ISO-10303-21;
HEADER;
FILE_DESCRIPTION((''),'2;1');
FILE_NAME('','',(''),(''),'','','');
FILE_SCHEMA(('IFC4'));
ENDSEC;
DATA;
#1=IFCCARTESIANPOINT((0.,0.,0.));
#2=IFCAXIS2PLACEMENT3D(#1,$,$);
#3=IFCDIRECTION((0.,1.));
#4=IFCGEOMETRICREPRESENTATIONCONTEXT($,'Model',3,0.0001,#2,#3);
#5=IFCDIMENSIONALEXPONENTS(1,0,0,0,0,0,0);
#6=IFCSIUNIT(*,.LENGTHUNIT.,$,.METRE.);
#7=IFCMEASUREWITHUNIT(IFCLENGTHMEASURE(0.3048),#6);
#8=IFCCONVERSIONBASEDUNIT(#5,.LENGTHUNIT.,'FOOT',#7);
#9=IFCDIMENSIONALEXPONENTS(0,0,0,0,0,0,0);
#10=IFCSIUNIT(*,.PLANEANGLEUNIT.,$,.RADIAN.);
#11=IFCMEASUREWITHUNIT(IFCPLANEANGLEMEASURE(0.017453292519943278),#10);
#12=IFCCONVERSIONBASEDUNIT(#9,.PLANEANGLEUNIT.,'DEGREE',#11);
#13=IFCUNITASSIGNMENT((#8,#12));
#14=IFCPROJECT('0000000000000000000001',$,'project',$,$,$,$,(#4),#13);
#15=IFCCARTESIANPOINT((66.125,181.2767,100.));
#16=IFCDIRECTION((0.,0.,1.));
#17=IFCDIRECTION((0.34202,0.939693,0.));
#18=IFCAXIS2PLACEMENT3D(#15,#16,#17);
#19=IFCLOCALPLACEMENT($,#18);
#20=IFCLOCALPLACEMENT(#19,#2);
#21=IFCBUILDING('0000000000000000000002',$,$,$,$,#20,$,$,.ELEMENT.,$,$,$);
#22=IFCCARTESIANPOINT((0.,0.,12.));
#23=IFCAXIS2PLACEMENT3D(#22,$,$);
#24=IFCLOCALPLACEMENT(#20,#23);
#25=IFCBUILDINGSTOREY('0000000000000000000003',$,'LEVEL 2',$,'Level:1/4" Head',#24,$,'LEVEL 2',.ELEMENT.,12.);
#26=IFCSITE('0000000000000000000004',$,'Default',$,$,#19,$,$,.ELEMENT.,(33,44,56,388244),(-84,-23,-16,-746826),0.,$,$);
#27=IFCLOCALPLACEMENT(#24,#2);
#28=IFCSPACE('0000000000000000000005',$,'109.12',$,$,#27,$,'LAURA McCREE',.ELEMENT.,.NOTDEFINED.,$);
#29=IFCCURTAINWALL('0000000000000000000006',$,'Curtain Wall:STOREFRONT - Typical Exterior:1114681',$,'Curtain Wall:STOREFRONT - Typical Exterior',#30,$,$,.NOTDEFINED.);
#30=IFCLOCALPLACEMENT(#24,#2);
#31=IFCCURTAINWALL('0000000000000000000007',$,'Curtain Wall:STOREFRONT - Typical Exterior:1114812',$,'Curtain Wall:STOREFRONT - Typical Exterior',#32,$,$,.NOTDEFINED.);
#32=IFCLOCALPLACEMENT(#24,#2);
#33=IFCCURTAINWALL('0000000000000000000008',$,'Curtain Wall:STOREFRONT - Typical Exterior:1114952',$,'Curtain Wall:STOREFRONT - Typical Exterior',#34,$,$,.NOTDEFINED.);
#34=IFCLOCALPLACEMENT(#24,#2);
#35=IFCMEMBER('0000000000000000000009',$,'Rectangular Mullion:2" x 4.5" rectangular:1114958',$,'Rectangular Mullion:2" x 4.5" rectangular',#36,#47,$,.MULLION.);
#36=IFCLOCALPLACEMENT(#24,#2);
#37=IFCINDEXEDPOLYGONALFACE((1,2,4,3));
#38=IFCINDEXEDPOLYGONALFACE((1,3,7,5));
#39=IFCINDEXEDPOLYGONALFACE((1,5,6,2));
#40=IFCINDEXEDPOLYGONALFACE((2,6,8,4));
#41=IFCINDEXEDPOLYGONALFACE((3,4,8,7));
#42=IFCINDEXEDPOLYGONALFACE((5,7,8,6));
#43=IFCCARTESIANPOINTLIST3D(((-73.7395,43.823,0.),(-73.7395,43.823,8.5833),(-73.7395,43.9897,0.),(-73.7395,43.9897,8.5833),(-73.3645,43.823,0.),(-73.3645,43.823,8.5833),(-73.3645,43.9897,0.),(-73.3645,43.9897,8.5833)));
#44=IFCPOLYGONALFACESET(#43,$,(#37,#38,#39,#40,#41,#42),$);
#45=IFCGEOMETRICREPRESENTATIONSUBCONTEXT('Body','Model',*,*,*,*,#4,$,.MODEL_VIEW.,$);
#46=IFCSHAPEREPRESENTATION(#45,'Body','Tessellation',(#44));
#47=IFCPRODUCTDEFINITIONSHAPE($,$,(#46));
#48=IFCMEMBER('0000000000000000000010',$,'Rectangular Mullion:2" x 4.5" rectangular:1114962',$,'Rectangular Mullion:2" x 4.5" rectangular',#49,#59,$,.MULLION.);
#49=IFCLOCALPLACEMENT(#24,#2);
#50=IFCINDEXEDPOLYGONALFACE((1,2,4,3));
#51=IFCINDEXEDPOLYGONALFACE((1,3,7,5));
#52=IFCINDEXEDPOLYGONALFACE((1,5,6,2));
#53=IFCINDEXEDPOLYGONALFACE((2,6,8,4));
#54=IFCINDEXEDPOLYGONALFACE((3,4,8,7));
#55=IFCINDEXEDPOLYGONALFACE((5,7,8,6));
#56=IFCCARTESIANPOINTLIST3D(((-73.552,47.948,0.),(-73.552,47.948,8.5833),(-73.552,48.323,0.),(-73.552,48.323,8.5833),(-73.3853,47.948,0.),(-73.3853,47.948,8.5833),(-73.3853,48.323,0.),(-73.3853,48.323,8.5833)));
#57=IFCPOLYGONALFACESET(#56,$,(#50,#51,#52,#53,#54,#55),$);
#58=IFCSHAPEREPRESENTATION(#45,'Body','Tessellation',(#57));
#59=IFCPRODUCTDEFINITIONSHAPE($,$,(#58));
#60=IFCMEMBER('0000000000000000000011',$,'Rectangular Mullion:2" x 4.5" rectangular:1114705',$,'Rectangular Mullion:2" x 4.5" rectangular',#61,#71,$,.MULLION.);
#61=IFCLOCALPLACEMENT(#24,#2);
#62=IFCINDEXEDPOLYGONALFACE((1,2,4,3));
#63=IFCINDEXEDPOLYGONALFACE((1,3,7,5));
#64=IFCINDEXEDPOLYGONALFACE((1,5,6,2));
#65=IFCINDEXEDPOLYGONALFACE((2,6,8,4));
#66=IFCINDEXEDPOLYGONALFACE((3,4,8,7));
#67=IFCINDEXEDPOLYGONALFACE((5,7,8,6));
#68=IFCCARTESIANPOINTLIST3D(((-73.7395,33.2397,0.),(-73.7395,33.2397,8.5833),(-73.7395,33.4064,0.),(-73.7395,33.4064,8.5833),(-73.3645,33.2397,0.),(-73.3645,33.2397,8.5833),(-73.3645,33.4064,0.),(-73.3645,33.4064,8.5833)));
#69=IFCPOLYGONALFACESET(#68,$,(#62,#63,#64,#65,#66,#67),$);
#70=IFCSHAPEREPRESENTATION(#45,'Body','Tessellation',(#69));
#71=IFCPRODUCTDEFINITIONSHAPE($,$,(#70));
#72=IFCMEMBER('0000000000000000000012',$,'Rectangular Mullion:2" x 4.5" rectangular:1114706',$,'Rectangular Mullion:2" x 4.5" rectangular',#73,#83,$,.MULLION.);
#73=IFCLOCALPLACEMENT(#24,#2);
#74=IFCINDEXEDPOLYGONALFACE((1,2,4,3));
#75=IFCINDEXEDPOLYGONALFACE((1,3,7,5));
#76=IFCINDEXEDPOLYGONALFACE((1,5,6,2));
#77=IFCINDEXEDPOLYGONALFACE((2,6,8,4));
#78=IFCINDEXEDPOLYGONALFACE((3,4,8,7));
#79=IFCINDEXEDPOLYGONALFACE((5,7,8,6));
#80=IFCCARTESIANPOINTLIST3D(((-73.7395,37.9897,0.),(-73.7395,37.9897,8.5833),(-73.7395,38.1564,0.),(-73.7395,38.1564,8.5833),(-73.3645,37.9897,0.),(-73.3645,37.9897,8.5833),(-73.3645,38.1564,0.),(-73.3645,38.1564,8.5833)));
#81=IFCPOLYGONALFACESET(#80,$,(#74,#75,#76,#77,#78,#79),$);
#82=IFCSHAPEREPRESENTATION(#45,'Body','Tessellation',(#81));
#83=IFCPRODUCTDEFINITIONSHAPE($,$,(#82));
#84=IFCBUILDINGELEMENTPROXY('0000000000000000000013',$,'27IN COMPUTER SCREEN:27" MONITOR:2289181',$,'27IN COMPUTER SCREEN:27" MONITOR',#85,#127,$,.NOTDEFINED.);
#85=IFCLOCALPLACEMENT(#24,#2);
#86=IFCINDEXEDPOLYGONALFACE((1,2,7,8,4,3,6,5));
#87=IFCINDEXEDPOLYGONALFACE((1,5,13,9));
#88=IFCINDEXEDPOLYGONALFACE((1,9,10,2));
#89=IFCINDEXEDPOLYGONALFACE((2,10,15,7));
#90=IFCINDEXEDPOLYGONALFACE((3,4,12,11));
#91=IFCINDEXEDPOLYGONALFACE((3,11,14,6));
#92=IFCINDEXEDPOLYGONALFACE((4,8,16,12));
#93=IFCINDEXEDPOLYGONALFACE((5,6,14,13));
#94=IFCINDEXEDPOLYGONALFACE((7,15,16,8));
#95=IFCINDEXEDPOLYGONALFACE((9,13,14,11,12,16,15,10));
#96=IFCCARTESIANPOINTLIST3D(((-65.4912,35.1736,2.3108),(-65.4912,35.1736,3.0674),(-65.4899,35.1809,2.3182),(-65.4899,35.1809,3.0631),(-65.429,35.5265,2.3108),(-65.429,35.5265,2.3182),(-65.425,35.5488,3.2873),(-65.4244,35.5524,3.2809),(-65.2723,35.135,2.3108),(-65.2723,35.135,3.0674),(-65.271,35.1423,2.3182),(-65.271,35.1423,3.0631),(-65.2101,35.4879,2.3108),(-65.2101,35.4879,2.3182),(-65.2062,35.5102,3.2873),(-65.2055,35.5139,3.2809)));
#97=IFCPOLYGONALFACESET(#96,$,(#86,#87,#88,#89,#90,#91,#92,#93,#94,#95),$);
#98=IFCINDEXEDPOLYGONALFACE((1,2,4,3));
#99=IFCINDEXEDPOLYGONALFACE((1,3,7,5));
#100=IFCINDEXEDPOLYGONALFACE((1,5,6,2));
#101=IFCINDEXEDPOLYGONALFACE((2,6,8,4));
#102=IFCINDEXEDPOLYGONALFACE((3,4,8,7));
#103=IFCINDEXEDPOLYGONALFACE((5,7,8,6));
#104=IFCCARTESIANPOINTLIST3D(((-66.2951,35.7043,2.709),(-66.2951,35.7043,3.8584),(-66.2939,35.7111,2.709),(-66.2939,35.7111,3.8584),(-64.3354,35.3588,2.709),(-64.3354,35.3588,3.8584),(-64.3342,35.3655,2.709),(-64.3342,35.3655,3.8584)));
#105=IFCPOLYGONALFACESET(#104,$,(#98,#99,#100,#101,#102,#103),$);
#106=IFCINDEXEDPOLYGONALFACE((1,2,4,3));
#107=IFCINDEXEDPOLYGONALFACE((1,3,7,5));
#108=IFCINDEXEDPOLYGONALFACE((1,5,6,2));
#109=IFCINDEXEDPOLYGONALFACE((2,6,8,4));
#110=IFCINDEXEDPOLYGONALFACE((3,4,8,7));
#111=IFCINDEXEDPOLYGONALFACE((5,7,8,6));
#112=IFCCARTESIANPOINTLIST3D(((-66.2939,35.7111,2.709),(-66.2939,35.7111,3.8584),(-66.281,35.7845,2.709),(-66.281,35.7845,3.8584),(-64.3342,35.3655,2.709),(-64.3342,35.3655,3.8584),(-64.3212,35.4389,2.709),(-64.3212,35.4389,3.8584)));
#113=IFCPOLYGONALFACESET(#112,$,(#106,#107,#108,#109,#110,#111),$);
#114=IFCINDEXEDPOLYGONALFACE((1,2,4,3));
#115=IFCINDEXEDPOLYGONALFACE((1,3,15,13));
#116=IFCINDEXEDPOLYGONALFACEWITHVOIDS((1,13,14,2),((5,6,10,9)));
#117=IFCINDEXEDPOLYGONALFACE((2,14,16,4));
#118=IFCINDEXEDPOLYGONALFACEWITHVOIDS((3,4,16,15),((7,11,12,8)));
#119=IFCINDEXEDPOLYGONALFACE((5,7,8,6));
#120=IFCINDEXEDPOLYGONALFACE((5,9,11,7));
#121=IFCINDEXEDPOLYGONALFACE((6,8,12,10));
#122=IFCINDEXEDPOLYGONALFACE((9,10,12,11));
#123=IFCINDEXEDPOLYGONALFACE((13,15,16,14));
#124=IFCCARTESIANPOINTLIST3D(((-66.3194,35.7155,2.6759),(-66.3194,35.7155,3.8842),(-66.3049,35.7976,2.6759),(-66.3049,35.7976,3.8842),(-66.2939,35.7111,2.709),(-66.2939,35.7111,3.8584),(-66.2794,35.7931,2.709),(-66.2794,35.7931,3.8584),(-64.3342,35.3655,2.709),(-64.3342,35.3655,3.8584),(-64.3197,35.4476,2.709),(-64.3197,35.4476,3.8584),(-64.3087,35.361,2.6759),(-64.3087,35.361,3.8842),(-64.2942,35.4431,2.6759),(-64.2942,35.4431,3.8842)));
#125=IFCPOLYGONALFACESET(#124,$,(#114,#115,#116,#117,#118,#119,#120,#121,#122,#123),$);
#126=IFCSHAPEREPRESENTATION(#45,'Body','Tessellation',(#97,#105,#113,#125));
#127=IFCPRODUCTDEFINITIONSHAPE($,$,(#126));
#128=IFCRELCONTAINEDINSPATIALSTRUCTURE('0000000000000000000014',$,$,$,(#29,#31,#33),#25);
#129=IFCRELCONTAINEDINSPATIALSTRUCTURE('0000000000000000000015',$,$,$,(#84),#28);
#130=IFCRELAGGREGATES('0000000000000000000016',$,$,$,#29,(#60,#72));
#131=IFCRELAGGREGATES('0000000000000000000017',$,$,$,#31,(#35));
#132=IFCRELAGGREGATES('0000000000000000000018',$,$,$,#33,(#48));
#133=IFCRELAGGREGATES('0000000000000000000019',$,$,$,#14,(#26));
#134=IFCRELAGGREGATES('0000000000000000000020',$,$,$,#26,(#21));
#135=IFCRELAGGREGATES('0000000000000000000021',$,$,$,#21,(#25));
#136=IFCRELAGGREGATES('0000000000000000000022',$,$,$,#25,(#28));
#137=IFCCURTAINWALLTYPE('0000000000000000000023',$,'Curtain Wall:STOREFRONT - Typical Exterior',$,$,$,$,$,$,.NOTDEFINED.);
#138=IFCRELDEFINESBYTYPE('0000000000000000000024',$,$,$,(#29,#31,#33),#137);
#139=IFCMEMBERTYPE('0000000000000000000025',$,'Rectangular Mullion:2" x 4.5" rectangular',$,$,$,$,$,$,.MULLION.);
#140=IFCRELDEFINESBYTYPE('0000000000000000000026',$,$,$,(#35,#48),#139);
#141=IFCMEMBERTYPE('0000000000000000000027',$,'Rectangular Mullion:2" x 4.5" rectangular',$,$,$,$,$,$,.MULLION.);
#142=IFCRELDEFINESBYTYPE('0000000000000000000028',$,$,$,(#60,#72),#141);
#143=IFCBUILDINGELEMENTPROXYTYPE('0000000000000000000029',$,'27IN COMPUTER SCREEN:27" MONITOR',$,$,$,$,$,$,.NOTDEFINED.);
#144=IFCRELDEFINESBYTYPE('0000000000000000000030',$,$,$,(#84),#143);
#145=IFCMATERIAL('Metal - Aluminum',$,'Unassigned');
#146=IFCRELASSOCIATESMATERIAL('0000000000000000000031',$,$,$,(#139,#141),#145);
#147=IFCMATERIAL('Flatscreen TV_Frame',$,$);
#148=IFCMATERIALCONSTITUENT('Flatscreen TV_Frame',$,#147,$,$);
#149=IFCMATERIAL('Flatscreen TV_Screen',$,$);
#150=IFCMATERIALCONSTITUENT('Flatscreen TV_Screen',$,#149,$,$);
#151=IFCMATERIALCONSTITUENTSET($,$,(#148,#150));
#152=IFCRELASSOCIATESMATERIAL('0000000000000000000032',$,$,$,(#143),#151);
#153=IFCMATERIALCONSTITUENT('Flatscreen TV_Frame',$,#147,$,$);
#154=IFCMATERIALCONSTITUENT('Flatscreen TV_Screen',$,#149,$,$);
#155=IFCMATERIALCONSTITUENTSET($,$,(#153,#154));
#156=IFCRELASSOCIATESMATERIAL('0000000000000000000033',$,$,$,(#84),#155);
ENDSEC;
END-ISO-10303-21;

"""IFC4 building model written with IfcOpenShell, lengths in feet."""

from ifc_helpers import new_model, entity, si_unit, converted_unit, direction, frame, frame_2d, origin, origin_2d_with_axis, place, context, subcontext, project, spatial, polyline, rectangle, outline, extrude, source, transform, mapped, material, constituent, constituent_set, material_profile, profile_set, type_object, type_shapes, element, aggregate, save


model = new_model("IFC4")

# Units and contexts
model_context = context("Model", 3, precision=0.0001, world=origin(), true_north=direction((0.0, 1.0)))
body_context = subcontext(model_context, "Body", "Model", "MODEL_VIEW")
ifc_project = project(units=[converted_unit("LENGTHUNIT", "FOOT", entity("IfcLengthMeasure", 0.3048), si_unit("LENGTHUNIT", "METRE"), dimensions=[1, 0, 0, 0, 0, 0, 0]), converted_unit("PLANEANGLEUNIT", "DEGREE", entity("IfcPlaneAngleMeasure", 0.017453292519943278), si_unit("PLANEANGLEUNIT", "RADIAN"), dimensions=[0, 0, 0, 0, 0, 0, 0])], contexts=[model_context])

# Site, building, storey
site_placement = place(None, frame((66.125, 181.2767, 100.0), z_axis=(0.0, 0.0, 1.0), x_axis=(0.34202, 0.939693, 0.0)))
site = spatial("IfcSite", under=ifc_project, at=site_placement, Name="Default", CompositionType="ELEMENT", RefLatitude=(33, 44, 56, 388244), RefLongitude=(-84, -23, -16, -746826), RefElevation=0.0)
building_placement = place(site_placement, origin())
building = spatial("IfcBuilding", under=site, at=building_placement, CompositionType="ELEMENT")
storey_placement = place(building_placement, frame((0.0, 0.0, 12.0)))
storey = spatial("IfcBuildingStorey", under=building, at=storey_placement, Name="LEVEL 2", ObjectType="Level:1/4\" Head", LongName="LEVEL 2", CompositionType="ELEMENT", Elevation=12.0)

# Curtain wall
curtain_wall_type = type_object("IfcCurtainWallType", Name="Curtain Wall:STOREFRONT - Typical Exterior", PredefinedType="NOTDEFINED")
curtain_wall_1_placement = place(storey_placement, frame((0.0, 0.0, -12.0)))
curtain_wall_1 = element("IfcCurtainWall", 1, at=curtain_wall_1_placement, inside=storey, type_object=curtain_wall_type, Name="Curtain Wall:STOREFRONT - Typical Exterior:1114681", ObjectType="Curtain Wall:STOREFRONT - Typical Exterior", PredefinedType="NOTDEFINED")
ifc_material_1 = material(Name="Metal - Aluminum", Category="Unassigned")
ifc_material_profile = material_profile(ifc_material_1, rectangle(XDim=0.1667, YDim=0.375, at=origin_2d_with_axis()), Name="2\" x 4.5\" rectangular")
ifc_profile_set = profile_set([ifc_material_profile], Name="2\" x 4.5\" rectangular")

# Curtain walls
curtain_wall_2_placement = place(storey_placement, frame((0.0, 0.0, -12.0)))
curtain_wall_2 = element("IfcCurtainWall", 2, at=curtain_wall_2_placement, inside=storey, type_object=curtain_wall_type, Name="Curtain Wall:STOREFRONT - Typical Exterior:1114812", ObjectType="Curtain Wall:STOREFRONT - Typical Exterior", PredefinedType="NOTDEFINED")
curtain_wall_3_placement = place(storey_placement, frame((0.0, 0.0, -12.0)))
curtain_wall_3 = element("IfcCurtainWall", 3, at=curtain_wall_3_placement, inside=storey, type_object=curtain_wall_type, Name="Curtain Wall:STOREFRONT - Typical Exterior:1114952", ObjectType="Curtain Wall:STOREFRONT - Typical Exterior", PredefinedType="NOTDEFINED")

# Members
member_type_1 = type_object("IfcMemberType", Name="Rectangular Mullion:2\" x 4.5\" rectangular", PredefinedType="MULLION", material=ifc_profile_set)
shared_shape_1 = source(origin(), body_context, "Body", "SweptSolid", [
    extrude(rectangle(XDim=0.1667, YDim=0.375, at=origin_2d_with_axis()), frame((-0.0833, 0.0, -8.5833), z_axis=(0.0, 0.0, 1.0), x_axis=(-1.0, 0.0, 0.0)), (0.0, 0.0, 1.0), 8.5833),
])
type_shapes(member_type_1, [shared_shape_1])
member_1_placement = place(curtain_wall_2_placement, frame((-73.552, 43.823, 20.5833), z_axis=(0.0, 0.0, 1.0), x_axis=(0.0, -1.0, 0.0)))
member_1 = element("IfcMember", 4, at=member_1_placement, type_object=member_type_1, Name="Rectangular Mullion:2\" x 4.5\" rectangular:1114958", ObjectType="Rectangular Mullion:2\" x 4.5\" rectangular", PredefinedType="MULLION", context=body_context, shape_type="MappedRepresentation", body=[
    mapped(shared_shape_1, transform((0.0, 0.0, 0.0), scale=1.0)),
])
member_2_placement = place(curtain_wall_3_placement, frame((-73.552, 48.1355, 20.5833), z_axis=(0.0, 0.0, 1.0), x_axis=(-1.0, 0.0, 0.0)))
member_2 = element("IfcMember", 5, at=member_2_placement, type_object=member_type_1, Name="Rectangular Mullion:2\" x 4.5\" rectangular:1114962", ObjectType="Rectangular Mullion:2\" x 4.5\" rectangular", PredefinedType="MULLION", context=body_context, shape_type="MappedRepresentation", body=[
    mapped(shared_shape_1, transform((0.0, 0.0, 0.0), scale=1.0)),
])
member_type_2 = type_object("IfcMemberType", Name="Rectangular Mullion:2\" x 4.5\" rectangular", PredefinedType="MULLION", material=ifc_profile_set)
shared_shape_2 = source(origin(), body_context, "Body", "SweptSolid", [
    extrude(rectangle(XDim=0.1667, YDim=0.375, at=frame_2d((0.0, 0.0), x_axis=(1.0, 0.0))), frame((0.0, 0.0, -8.5833), z_axis=(0.0, 0.0, 1.0), x_axis=(-1.0, 0.0, 0.0)), (0.0, 0.0, 1.0), 8.5833),
])
type_shapes(member_type_2, [shared_shape_2])
member_3_placement = place(curtain_wall_1_placement, frame((-73.552, 33.323, 12.0), z_axis=(0.0, 0.0, -1.0), x_axis=(0.0, 1.0, 0.0)))
member_3 = element("IfcMember", 6, at=member_3_placement, type_object=member_type_2, Name="Rectangular Mullion:2\" x 4.5\" rectangular:1114705", ObjectType="Rectangular Mullion:2\" x 4.5\" rectangular", PredefinedType="MULLION", context=body_context, shape_type="MappedRepresentation", body=[
    mapped(shared_shape_2, transform((0.0, 0.0, 0.0), scale=1.0)),
])
member_4_placement = place(curtain_wall_1_placement, frame((-73.552, 38.073, 12.0), z_axis=(0.0, 0.0, -1.0), x_axis=(0.0, 1.0, 0.0)))
member_4 = element("IfcMember", 7, at=member_4_placement, type_object=member_type_2, Name="Rectangular Mullion:2\" x 4.5\" rectangular:1114706", ObjectType="Rectangular Mullion:2\" x 4.5\" rectangular", PredefinedType="MULLION", context=body_context, shape_type="MappedRepresentation", body=[
    mapped(shared_shape_2, transform((0.0, 0.0, 0.0), scale=1.0)),
])

aggregate(curtain_wall_1, [member_3, member_4])
aggregate(curtain_wall_2, [member_1])
aggregate(curtain_wall_3, [member_2])

# Shared definitions
space_placement = place(storey_placement, origin())
space = spatial("IfcSpace", under=storey, at=space_placement, Name="109.12", LongName="LAURA McCREE", CompositionType="ELEMENT", PredefinedType="NOTDEFINED")

# Building element proxy
ifc_material_2 = material(Name="Flatscreen TV_Frame")
ifc_constituent_1 = constituent(ifc_material_2, Name="Flatscreen TV_Frame")
ifc_material_3 = material(Name="Flatscreen TV_Screen")
ifc_constituent_2 = constituent(ifc_material_3, Name="Flatscreen TV_Screen")
ifc_constituent_set_1 = constituent_set(constituents=[ifc_constituent_1, ifc_constituent_2])
ifc_constituent_3 = constituent(ifc_material_2, Name="Flatscreen TV_Frame")
ifc_constituent_4 = constituent(ifc_material_3, Name="Flatscreen TV_Screen")
ifc_constituent_set_2 = constituent_set(constituents=[ifc_constituent_3, ifc_constituent_4])
building_element_proxy_type = type_object("IfcBuildingElementProxyType", Name="27IN COMPUTER SCREEN:27\" MONITOR", PredefinedType="NOTDEFINED", material=ifc_constituent_set_2)
shared_shape_3 = source(origin(), body_context, "Body", "SweptSolid", [
    extrude(outline(polyline([(-0.4392, -0.3657), (-0.4392, -0.3731), (0.0007, -0.3731), (0.379, 0.2821), (0.0686, 0.4613), (0.0649, 0.4548), (0.3688, 0.2794), (-0.0036, -0.3657), (-0.4392, -0.3657)])), frame((-0.1111, -0.0264, 0.0687), z_axis=(-1.0, 0.0, 0.0), x_axis=(0.0, 0.866025, -0.5)), (0.0, 0.0, -1.0), 0.2222),
    extrude(rectangle(XDim=0.0068, YDim=1.9899, at=origin_2d_with_axis()), frame((0.0, -0.2257, 0.0331), z_axis=(0.0, 0.0, 1.0), x_axis=(0.0, 1.0, 0.0)), (0.0, 0.0, 1.0), 1.1493),
    extrude(rectangle(XDim=0.0746, YDim=1.9899, at=frame_2d((0.0, 0.0), x_axis=(1.0, 0.0))), frame((0.0, -0.2664, 0.0331), z_axis=(0.0, 0.0, 1.0), x_axis=(0.0, 1.0, 0.0)), (0.0, 0.0, 1.0), 1.1493),
    extrude(outline(polyline([(-0.6042, -1.0208), (0.6042, -1.0208), (0.6042, 1.0208), (-0.6042, 1.0208), (-0.6042, -1.0208)]), holes=[polyline([(-0.5783, -0.995), (-0.5783, 0.995), (0.571, 0.995), (0.571, -0.995), (-0.5783, -0.995)])]), frame((0.0, -0.3125, 0.6042), z_axis=(0.0, 1.0, 0.0), x_axis=(0.0, 0.0, -1.0)), (0.0, 0.0, 1.0), 0.0833),
])
type_shapes(building_element_proxy_type, [shared_shape_3])
proxy_placement = place(space_placement, frame((-65.3538, 35.3126, 2.6759), z_axis=(0.0, 0.0, 1.0), x_axis=(-0.984808, 0.173648, 0.0)))
element("IfcBuildingElementProxy", 8, at=proxy_placement, inside=space, type_object=building_element_proxy_type, material=ifc_constituent_set_1, Name="27IN COMPUTER SCREEN:27\" MONITOR:2289181", ObjectType="27IN COMPUTER SCREEN:27\" MONITOR", PredefinedType="NOTDEFINED", context=body_context, shape_type="MappedRepresentation", body=[
    mapped(shared_shape_3, transform((0.0, 0.0, 0.0), scale=1.0)),
])

save(model, "model.ifc")
